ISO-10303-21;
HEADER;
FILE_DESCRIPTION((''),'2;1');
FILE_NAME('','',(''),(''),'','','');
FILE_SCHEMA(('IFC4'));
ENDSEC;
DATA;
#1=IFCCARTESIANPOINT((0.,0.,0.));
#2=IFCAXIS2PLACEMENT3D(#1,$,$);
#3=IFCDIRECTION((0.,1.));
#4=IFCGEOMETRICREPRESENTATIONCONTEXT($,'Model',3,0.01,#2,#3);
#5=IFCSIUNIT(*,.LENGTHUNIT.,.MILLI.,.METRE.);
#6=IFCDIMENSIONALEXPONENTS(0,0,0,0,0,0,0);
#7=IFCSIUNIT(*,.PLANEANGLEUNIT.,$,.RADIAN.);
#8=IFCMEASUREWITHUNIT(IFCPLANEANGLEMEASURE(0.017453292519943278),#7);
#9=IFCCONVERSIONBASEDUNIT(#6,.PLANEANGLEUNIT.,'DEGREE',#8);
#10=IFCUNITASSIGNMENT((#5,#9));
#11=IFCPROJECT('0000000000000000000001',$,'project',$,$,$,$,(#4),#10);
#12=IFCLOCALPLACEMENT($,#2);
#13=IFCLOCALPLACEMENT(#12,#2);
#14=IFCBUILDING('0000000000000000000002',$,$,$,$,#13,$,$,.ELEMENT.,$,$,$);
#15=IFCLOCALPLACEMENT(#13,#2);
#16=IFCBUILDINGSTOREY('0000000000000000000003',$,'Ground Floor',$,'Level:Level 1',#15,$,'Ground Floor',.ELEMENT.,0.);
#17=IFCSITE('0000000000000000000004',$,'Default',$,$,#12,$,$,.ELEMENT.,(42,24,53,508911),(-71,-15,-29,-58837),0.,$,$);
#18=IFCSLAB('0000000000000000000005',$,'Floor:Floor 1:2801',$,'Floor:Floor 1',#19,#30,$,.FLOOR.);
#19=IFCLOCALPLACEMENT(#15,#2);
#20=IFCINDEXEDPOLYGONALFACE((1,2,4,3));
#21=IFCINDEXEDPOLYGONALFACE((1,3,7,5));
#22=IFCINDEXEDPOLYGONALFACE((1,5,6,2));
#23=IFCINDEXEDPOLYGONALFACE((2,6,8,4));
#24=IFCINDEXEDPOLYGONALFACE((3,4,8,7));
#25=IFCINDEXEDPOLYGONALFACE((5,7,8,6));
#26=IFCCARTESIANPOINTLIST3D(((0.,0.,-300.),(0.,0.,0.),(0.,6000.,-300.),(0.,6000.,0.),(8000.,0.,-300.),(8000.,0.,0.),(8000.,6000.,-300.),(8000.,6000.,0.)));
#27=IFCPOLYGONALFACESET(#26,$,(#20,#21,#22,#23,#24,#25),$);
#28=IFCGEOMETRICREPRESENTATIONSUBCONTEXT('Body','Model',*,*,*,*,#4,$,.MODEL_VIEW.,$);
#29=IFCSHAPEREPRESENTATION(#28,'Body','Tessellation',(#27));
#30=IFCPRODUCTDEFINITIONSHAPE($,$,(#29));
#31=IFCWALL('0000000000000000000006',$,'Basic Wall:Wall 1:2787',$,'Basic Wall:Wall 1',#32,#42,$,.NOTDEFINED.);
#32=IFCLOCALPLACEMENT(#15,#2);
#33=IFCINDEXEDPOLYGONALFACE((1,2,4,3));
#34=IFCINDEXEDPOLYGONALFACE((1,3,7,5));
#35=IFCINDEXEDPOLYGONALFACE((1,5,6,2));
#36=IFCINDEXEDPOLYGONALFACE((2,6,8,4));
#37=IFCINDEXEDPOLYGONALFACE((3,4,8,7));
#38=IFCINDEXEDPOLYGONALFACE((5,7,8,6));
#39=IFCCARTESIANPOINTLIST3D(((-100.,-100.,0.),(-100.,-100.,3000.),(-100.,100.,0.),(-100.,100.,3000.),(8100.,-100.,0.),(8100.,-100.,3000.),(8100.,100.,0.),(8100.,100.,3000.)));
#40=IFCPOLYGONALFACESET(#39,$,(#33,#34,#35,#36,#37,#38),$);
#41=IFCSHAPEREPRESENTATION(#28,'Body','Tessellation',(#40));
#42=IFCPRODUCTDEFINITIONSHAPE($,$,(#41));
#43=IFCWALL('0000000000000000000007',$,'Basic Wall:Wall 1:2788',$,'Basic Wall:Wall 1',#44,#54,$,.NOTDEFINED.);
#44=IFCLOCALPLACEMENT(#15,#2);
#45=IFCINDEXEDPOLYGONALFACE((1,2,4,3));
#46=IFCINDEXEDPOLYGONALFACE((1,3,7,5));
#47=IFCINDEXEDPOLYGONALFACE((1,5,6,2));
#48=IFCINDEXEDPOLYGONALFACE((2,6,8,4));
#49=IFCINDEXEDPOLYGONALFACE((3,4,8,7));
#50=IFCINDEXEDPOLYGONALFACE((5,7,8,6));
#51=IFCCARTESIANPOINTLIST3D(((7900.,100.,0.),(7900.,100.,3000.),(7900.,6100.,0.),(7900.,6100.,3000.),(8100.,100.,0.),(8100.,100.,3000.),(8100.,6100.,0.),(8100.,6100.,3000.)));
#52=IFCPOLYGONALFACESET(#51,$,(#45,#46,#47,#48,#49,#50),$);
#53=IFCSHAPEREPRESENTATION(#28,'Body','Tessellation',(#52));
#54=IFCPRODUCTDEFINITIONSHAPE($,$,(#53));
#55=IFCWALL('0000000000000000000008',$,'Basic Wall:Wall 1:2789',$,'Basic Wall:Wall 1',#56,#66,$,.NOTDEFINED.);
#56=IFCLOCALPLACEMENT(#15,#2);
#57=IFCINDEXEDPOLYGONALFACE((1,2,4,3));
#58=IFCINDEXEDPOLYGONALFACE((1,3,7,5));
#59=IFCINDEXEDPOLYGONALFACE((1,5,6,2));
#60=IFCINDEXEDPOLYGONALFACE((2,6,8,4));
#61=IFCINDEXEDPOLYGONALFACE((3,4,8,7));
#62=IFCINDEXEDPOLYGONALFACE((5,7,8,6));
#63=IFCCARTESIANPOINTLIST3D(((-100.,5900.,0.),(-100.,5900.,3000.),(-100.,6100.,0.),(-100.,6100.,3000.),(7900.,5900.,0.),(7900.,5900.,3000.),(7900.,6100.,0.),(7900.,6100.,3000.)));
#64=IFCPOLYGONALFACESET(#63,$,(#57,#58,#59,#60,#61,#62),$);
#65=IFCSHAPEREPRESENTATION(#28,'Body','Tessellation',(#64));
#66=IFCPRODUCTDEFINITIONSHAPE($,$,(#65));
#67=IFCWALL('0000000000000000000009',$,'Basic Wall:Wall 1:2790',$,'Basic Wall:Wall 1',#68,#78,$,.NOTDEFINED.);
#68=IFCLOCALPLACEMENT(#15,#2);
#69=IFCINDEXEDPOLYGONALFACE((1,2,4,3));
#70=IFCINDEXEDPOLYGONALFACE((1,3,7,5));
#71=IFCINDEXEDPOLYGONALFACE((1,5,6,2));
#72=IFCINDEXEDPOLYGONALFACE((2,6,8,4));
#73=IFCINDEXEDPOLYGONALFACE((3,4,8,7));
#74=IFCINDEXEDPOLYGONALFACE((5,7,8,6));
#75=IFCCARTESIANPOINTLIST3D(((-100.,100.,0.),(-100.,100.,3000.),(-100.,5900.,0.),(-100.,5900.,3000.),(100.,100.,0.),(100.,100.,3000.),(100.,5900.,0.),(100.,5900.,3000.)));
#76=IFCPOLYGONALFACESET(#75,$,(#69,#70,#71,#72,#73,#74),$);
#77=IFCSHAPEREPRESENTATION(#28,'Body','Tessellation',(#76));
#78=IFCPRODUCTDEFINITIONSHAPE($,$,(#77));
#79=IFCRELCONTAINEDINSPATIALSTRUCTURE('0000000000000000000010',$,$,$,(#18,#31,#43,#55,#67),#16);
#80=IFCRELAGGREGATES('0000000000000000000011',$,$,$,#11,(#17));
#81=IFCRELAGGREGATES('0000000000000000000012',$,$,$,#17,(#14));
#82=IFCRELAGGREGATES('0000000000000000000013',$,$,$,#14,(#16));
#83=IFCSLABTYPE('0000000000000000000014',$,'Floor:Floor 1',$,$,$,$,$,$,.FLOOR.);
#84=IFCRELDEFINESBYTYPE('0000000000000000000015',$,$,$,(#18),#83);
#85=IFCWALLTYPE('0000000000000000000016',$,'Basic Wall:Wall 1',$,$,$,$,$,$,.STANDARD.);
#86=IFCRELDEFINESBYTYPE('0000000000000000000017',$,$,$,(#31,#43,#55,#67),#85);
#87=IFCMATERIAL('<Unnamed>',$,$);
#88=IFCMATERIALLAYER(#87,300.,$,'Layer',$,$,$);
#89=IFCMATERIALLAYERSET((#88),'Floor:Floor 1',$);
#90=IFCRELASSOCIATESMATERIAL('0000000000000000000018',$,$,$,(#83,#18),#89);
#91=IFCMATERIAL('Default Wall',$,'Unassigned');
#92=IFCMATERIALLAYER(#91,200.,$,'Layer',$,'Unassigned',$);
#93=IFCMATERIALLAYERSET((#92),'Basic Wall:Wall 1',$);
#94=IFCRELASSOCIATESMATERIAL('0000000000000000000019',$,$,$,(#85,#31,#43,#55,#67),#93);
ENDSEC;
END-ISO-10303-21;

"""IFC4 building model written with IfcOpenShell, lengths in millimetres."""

from ifc_helpers import new_model, entity, si_unit, converted_unit, direction, frame, frame_2d, origin, origin_2d_with_axis, place, context, subcontext, project, spatial, rectangle, extrude, material, layer, layer_set, layer_usage, type_object, element, save


model = new_model("IFC4")

# Units and contexts
model_context = context("Model", 3, precision=0.01, world=origin(), true_north=direction((0.0, 1.0)))
body_context = subcontext(model_context, "Body", "Model", "MODEL_VIEW")
ifc_project = project(units=[si_unit("LENGTHUNIT", "METRE", prefix="MILLI"), converted_unit("PLANEANGLEUNIT", "DEGREE", entity("IfcPlaneAngleMeasure", 0.017453292519943278), si_unit("PLANEANGLEUNIT", "RADIAN"), dimensions=[0, 0, 0, 0, 0, 0, 0])], contexts=[model_context])

# Site, building, storey
site_placement = place(None, origin())
site = spatial("IfcSite", under=ifc_project, at=site_placement, Name="Default", CompositionType="ELEMENT", RefLatitude=(42, 24, 53, 508911), RefLongitude=(-71, -15, -29, -58837), RefElevation=0.0)
building_placement = place(site_placement, origin())
building = spatial("IfcBuilding", under=site, at=building_placement, CompositionType="ELEMENT")
storey_placement = place(building_placement, origin())
storey = spatial("IfcBuildingStorey", under=building, at=storey_placement, Name="Ground Floor", ObjectType="Level:Level 1", LongName="Ground Floor", CompositionType="ELEMENT", Elevation=0.0)

# Slab
ifc_material_1 = material(Name="<Unnamed>")
ifc_layer_1 = layer(ifc_material_1, 300.0, Name="Layer")
ifc_layer_set_1 = layer_set([ifc_layer_1], Name="Floor:Floor 1")
ifc_layer_usage_1 = layer_usage(ifc_layer_set_1, "AXIS3", "POSITIVE", 0.0)
slab_type = type_object("IfcSlabType", Name="Floor:Floor 1", PredefinedType="FLOOR", material=ifc_layer_set_1)
slab_placement = place(storey_placement, origin())
element("IfcSlab", 1, at=slab_placement, inside=storey, type_object=slab_type, material=ifc_layer_usage_1, Name="Floor:Floor 1:2801", ObjectType="Floor:Floor 1", PredefinedType="FLOOR", context=body_context, shape_type="SweptSolid", body=[
    extrude(rectangle(XDim=6000.0, YDim=8000.0, at=origin_2d_with_axis()), frame((4000.0, 3000.0, 0.0), z_axis=(0.0, 0.0, -1.0), x_axis=(0.0, 1.0, 0.0)), (0.0, 0.0, 1.0), 300.0),
])

# Walls
ifc_material_2 = material(Name="Default Wall", Category="Unassigned")
ifc_layer_2 = layer(ifc_material_2, 200.0, Name="Layer", Category="Unassigned")
ifc_layer_set_2 = layer_set([ifc_layer_2], Name="Basic Wall:Wall 1")
ifc_layer_usage_2 = layer_usage(ifc_layer_set_2, "AXIS2", "NEGATIVE", 100.0)
wall_type = type_object("IfcWallType", Name="Basic Wall:Wall 1", PredefinedType="STANDARD", material=ifc_layer_set_2)
wall_1_placement = place(storey_placement, frame((-100.0, 0.0, 0.0)))
element("IfcWall", 2, at=wall_1_placement, inside=storey, type_object=wall_type, material=ifc_layer_usage_2, Name="Basic Wall:Wall 1:2787", ObjectType="Basic Wall:Wall 1", PredefinedType="NOTDEFINED", context=body_context, shape_type="SweptSolid", body=[
    extrude(rectangle(XDim=8200.0, YDim=200.0, at=frame_2d((4100.0, 0.0), x_axis=(-1.0, 0.0))), origin(), (0.0, 0.0, 1.0), 3000.0),
])
ifc_layer_usage_3 = layer_usage(ifc_layer_set_2, "AXIS2", "NEGATIVE", 100.0)
wall_2_placement = place(storey_placement, frame((8000.0, 100.0, 0.0), z_axis=(0.0, 0.0, 1.0), x_axis=(0.0, 1.0, 0.0)))
element("IfcWall", 3, at=wall_2_placement, inside=storey, type_object=wall_type, material=ifc_layer_usage_3, Name="Basic Wall:Wall 1:2788", ObjectType="Basic Wall:Wall 1", PredefinedType="NOTDEFINED", context=body_context, shape_type="SweptSolid", body=[
    extrude(rectangle(XDim=6000.0, YDim=200.0, at=frame_2d((3000.0, 0.0), x_axis=(-1.0, 0.0))), origin(), (0.0, 0.0, 1.0), 3000.0),
])
ifc_layer_usage_4 = layer_usage(ifc_layer_set_2, "AXIS2", "NEGATIVE", 100.0)
wall_3_placement = place(storey_placement, frame((7900.0, 6000.0, 0.0), z_axis=(0.0, 0.0, 1.0), x_axis=(-1.0, 0.0, 0.0)))
element("IfcWall", 4, at=wall_3_placement, inside=storey, type_object=wall_type, material=ifc_layer_usage_4, Name="Basic Wall:Wall 1:2789", ObjectType="Basic Wall:Wall 1", PredefinedType="NOTDEFINED", context=body_context, shape_type="SweptSolid", body=[
    extrude(rectangle(XDim=8000.0, YDim=200.0, at=frame_2d((4000.0, 0.0), x_axis=(-1.0, 0.0))), origin(), (0.0, 0.0, 1.0), 3000.0),
])
ifc_layer_usage_5 = layer_usage(ifc_layer_set_2, "AXIS2", "NEGATIVE", 100.0)
wall_4_placement = place(storey_placement, frame((0.0, 5900.0, 0.0), z_axis=(0.0, 0.0, 1.0), x_axis=(0.0, -1.0, 0.0)))
element("IfcWall", 5, at=wall_4_placement, inside=storey, type_object=wall_type, material=ifc_layer_usage_5, Name="Basic Wall:Wall 1:2790", ObjectType="Basic Wall:Wall 1", PredefinedType="NOTDEFINED", context=body_context, shape_type="SweptSolid", body=[
    extrude(rectangle(XDim=5800.0, YDim=200.0, at=frame_2d((2900.0, 0.0), x_axis=(-1.0, 0.0))), origin(), (0.0, 0.0, 1.0), 3000.0),
])

save(model, "model.ifc")
